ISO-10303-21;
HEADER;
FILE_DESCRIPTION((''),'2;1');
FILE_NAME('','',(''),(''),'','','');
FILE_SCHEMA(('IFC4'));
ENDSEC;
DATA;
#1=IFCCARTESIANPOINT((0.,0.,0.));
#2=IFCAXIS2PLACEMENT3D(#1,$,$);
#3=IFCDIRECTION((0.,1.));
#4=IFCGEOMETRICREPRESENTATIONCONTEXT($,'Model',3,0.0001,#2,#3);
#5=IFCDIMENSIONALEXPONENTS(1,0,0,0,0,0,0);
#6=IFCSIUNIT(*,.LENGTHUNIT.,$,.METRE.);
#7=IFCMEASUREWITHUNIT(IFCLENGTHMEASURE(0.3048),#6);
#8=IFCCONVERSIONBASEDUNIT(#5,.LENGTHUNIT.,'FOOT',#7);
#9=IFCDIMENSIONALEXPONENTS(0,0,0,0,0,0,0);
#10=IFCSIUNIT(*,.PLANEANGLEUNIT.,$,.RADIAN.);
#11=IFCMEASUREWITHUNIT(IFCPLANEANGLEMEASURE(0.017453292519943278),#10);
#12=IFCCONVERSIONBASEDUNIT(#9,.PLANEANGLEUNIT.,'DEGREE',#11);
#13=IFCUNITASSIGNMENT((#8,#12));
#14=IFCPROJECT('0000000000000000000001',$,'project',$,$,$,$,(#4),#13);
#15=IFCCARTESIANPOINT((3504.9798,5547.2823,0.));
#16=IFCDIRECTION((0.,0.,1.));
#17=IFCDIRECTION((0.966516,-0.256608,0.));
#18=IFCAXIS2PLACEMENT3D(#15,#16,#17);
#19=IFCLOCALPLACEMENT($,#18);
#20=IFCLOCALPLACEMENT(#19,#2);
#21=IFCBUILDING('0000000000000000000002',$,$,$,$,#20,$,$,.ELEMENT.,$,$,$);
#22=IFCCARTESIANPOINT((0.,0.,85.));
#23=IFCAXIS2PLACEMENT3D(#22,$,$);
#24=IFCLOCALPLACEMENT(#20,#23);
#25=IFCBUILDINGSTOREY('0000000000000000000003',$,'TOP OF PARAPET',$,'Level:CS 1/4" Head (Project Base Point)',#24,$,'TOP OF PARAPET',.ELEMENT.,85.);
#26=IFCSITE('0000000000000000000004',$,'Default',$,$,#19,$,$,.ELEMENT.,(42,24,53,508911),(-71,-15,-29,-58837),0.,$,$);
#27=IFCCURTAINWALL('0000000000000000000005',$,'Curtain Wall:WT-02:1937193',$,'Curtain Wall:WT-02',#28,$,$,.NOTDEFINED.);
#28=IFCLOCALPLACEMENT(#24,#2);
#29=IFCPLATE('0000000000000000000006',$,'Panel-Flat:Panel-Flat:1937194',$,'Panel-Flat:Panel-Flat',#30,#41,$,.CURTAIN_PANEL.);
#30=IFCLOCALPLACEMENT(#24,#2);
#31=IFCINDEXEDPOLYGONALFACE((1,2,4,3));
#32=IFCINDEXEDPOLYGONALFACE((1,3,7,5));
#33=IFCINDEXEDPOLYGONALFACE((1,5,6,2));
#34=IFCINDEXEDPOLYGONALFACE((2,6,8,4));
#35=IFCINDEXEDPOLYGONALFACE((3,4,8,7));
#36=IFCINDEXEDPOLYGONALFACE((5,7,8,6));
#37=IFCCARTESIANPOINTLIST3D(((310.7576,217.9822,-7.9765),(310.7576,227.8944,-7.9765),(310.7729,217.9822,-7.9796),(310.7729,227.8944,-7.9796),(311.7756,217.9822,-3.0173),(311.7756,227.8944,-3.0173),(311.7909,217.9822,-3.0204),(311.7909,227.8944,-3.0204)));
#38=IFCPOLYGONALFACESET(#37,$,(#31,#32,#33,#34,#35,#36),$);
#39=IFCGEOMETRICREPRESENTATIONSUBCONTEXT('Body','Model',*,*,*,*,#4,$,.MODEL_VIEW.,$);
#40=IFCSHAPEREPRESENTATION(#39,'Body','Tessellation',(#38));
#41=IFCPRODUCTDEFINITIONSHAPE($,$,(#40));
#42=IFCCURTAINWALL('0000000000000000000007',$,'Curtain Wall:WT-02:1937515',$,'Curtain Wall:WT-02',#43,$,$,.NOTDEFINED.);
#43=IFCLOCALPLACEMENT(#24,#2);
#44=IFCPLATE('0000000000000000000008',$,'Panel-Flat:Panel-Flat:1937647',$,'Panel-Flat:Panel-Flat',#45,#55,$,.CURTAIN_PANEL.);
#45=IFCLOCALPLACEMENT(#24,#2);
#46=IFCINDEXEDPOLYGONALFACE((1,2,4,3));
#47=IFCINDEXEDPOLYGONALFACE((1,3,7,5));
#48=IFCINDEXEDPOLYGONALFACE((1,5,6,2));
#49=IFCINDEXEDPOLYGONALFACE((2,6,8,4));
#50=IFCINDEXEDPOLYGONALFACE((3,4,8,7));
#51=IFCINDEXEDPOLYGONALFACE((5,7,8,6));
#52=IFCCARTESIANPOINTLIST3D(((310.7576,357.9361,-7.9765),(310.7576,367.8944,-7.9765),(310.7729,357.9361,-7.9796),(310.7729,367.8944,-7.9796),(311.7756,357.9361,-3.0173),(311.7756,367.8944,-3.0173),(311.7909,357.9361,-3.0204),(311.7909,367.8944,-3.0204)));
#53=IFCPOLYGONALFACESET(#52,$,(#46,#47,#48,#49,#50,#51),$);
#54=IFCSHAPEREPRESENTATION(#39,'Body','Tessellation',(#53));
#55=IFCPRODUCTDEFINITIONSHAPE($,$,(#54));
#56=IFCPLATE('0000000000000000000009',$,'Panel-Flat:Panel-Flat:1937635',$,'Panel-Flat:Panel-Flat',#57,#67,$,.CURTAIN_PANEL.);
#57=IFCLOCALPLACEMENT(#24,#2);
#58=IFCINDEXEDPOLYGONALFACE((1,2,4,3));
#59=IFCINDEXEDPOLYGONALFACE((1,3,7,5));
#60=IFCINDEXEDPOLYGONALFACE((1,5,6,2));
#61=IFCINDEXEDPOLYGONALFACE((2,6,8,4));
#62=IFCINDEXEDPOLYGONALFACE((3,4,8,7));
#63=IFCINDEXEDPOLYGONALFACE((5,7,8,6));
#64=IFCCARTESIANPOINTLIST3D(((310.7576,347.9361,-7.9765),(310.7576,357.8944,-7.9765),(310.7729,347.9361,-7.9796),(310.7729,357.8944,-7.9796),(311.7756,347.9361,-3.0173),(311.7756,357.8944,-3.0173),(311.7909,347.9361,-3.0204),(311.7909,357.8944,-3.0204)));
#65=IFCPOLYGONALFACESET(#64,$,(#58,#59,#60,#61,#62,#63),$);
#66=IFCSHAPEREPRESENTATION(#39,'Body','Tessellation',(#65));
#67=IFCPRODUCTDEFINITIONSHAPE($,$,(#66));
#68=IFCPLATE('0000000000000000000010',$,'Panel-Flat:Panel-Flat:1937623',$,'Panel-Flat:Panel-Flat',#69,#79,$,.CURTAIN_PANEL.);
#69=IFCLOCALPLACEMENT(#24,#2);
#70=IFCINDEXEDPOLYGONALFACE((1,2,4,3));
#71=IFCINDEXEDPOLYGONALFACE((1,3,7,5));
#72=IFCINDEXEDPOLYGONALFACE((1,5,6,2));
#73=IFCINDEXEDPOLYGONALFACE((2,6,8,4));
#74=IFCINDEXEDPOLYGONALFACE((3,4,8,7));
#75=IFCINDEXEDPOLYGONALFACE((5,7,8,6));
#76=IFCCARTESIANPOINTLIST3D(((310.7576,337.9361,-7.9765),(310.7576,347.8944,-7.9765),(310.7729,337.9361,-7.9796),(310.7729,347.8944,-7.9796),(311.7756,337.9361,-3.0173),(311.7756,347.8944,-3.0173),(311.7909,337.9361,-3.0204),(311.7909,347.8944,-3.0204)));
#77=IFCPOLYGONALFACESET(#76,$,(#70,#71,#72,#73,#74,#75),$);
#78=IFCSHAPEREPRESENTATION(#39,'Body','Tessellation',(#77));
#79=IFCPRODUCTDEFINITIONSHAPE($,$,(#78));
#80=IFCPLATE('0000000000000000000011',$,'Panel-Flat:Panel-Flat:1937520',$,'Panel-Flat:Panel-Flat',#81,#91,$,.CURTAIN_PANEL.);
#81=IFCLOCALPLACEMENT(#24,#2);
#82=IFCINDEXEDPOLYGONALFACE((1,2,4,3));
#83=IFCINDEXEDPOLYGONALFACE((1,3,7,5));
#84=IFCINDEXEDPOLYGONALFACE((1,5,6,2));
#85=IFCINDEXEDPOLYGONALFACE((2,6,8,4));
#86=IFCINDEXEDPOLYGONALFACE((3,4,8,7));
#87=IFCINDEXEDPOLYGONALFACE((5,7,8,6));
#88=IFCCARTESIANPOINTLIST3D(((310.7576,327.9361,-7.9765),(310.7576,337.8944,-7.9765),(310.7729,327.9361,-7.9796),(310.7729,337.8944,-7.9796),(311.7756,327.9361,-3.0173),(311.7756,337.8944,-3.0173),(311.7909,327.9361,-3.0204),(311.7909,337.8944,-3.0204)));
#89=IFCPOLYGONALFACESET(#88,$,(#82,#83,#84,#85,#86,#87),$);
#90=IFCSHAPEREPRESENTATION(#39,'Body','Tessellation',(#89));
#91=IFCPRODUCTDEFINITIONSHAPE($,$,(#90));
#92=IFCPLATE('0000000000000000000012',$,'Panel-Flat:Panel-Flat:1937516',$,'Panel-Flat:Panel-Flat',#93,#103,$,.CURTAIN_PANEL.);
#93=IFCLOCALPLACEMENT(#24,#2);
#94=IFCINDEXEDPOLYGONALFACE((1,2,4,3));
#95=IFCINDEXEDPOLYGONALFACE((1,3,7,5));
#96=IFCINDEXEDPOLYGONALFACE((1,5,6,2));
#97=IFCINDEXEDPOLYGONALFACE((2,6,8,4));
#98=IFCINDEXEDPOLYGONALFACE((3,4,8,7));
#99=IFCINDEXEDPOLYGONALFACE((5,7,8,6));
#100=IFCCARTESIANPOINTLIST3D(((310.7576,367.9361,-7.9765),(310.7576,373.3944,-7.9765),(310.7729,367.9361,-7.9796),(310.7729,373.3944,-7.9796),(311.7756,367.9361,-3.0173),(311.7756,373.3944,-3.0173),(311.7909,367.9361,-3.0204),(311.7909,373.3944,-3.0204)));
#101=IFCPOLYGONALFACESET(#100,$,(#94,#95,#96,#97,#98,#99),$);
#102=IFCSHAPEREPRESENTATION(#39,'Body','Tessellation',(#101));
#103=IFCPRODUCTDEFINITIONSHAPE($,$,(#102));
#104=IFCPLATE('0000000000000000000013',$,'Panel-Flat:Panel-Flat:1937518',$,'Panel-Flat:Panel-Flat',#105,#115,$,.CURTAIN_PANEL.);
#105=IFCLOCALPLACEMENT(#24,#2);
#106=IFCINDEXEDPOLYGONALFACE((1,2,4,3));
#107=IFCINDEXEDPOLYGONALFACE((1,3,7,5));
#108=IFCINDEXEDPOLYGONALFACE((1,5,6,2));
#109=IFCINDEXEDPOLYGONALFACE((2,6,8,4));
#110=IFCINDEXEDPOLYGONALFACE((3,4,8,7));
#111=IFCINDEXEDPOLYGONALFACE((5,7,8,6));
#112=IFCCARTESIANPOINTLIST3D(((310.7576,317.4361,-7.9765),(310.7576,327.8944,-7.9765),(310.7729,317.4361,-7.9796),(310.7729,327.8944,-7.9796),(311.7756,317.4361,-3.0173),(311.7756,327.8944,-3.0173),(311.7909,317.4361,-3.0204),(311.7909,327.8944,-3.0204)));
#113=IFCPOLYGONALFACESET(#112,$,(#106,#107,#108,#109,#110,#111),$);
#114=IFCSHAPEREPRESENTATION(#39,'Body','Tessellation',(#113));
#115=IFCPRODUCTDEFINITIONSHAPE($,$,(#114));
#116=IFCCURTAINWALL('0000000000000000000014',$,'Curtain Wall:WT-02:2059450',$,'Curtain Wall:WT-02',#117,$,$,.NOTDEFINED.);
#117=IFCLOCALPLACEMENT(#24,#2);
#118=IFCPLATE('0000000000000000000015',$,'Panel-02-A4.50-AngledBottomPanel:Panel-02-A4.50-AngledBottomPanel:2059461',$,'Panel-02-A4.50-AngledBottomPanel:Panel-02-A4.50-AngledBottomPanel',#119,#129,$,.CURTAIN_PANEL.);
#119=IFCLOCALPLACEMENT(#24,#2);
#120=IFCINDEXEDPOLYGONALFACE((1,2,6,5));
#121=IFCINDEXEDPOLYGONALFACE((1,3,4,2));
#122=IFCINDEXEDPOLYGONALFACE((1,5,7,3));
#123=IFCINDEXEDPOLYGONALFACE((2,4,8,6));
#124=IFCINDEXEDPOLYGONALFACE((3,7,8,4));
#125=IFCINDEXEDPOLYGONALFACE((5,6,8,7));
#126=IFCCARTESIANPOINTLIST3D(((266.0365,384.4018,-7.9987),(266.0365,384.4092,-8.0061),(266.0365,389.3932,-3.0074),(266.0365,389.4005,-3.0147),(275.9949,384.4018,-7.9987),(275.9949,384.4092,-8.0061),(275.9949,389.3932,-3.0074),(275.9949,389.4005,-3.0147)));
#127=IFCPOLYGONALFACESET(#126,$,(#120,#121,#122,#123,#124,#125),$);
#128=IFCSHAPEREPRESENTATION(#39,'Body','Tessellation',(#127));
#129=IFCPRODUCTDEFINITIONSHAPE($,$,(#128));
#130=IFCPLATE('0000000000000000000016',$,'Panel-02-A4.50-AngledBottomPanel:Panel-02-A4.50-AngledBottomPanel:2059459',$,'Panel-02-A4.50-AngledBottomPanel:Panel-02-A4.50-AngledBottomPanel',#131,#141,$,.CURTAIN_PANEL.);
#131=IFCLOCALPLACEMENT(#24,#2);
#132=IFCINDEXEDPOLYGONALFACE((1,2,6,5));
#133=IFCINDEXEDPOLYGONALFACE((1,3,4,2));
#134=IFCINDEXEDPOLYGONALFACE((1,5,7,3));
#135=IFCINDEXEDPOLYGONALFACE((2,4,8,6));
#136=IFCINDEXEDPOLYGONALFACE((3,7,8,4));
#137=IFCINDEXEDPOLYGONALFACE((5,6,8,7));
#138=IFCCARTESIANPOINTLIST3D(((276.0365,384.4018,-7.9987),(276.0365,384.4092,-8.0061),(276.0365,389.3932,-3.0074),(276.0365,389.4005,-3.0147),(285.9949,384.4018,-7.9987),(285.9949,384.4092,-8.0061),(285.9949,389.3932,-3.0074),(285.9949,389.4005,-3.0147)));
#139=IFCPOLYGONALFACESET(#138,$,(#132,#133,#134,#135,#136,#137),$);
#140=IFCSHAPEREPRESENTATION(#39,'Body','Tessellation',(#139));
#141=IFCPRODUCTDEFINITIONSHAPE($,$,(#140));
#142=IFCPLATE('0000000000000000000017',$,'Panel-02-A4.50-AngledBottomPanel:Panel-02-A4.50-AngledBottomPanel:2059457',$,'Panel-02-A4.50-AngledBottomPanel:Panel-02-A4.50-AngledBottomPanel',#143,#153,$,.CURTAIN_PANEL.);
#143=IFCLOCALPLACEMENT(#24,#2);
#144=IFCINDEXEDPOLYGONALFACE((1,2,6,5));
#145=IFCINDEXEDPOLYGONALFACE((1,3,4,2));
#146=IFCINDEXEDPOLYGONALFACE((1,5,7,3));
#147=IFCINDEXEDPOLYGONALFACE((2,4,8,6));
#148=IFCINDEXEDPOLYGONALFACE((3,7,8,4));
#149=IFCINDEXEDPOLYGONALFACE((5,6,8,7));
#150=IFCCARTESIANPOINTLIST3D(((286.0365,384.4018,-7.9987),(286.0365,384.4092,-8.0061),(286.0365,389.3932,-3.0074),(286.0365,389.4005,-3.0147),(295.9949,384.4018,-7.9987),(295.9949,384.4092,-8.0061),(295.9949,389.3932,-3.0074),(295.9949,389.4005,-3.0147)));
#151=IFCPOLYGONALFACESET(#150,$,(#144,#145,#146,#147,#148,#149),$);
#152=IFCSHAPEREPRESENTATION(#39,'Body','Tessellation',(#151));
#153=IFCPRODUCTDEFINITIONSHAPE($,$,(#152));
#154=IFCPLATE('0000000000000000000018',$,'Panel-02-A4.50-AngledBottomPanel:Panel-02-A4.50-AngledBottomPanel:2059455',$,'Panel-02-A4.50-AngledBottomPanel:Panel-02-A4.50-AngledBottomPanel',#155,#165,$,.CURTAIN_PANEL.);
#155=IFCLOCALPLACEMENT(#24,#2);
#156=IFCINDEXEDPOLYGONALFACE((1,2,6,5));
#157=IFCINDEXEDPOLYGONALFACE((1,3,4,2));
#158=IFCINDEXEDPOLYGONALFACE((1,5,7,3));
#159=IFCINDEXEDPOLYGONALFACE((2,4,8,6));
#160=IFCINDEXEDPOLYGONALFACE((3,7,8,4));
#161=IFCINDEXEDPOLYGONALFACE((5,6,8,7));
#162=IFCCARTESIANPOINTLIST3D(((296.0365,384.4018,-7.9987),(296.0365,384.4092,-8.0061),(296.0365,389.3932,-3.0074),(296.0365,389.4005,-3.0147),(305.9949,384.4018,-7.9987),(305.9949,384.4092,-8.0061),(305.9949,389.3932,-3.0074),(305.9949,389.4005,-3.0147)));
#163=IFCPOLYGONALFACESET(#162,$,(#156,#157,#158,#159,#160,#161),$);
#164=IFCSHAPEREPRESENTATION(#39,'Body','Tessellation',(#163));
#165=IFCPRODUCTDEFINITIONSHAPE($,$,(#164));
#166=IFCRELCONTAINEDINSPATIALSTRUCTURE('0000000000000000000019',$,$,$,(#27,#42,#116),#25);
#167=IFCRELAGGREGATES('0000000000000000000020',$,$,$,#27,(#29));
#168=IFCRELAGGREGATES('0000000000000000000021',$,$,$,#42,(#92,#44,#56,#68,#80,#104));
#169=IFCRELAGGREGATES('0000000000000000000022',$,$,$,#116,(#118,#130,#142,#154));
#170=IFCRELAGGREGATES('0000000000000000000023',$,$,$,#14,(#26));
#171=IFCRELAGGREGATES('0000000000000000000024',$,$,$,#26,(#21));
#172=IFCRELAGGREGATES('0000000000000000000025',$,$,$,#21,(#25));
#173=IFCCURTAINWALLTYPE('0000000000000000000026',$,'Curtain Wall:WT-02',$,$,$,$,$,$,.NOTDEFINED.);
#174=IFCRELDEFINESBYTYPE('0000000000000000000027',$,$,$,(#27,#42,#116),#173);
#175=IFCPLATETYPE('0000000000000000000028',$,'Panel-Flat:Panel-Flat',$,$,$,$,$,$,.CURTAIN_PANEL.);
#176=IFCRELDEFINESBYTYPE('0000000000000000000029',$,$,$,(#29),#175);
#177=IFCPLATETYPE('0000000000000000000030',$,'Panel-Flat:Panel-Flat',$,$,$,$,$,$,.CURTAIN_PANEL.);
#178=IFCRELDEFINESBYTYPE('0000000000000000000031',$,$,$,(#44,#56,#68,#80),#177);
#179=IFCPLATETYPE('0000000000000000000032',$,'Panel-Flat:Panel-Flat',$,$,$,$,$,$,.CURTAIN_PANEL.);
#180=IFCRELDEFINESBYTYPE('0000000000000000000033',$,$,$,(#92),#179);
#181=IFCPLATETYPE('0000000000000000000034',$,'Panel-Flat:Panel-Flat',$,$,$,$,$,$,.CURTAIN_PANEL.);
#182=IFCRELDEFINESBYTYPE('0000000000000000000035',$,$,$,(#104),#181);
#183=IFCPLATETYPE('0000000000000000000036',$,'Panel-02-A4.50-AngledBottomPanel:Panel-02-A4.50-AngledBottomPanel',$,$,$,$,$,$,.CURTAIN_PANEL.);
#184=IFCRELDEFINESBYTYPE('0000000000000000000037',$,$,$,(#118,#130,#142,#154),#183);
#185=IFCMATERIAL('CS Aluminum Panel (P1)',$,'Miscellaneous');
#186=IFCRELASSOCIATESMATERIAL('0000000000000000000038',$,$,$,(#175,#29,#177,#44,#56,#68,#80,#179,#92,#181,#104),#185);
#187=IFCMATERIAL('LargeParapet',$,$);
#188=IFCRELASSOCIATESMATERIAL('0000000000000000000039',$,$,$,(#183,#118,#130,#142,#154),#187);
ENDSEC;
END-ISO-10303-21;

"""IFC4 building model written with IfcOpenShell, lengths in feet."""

from ifc_helpers import new_model, entity, si_unit, converted_unit, direction, frame, origin, place, context, subcontext, project, spatial, indexed_curve, outline, extrude, source, transform, mapped, material, type_object, type_shapes, element, aggregate, save


model = new_model("IFC4")

# Units and contexts
model_context = context("Model", 3, precision=0.0001, world=origin(), true_north=direction((0.0, 1.0)))
body_context = subcontext(model_context, "Body", "Model", "MODEL_VIEW")
ifc_project = project(units=[converted_unit("LENGTHUNIT", "FOOT", entity("IfcLengthMeasure", 0.3048), si_unit("LENGTHUNIT", "METRE"), dimensions=[1, 0, 0, 0, 0, 0, 0]), converted_unit("PLANEANGLEUNIT", "DEGREE", entity("IfcPlaneAngleMeasure", 0.017453292519943278), si_unit("PLANEANGLEUNIT", "RADIAN"), dimensions=[0, 0, 0, 0, 0, 0, 0])], contexts=[model_context])

# Site, building, storey
site_placement = place(None, frame((3504.9798, 5547.2823, 0.0), z_axis=(0.0, 0.0, 1.0), x_axis=(0.966516, -0.256608, 0.0)))
site = spatial("IfcSite", under=ifc_project, at=site_placement, Name="Default", CompositionType="ELEMENT", RefLatitude=(42, 24, 53, 508911), RefLongitude=(-71, -15, -29, -58837), RefElevation=0.0)
building_placement = place(site_placement, origin())
building = spatial("IfcBuilding", under=site, at=building_placement, CompositionType="ELEMENT")
storey_placement = place(building_placement, frame((0.0, 0.0, 85.0)))
storey = spatial("IfcBuildingStorey", under=building, at=storey_placement, Name="TOP OF PARAPET", ObjectType="Level:CS 1/4\" Head (Project Base Point)", LongName="TOP OF PARAPET", CompositionType="ELEMENT", Elevation=85.0)

# Shared definitions
curtain_wall_type = type_object("IfcCurtainWallType", Name="Curtain Wall:WT-02", PredefinedType="NOTDEFINED")
ifc_material_1 = material(Name="LargeParapet")

# Curtain wall, plate
curtain_wall_1_placement = place(storey_placement, frame((0.0, 0.0, -85.0)))
curtain_wall_1 = element("IfcCurtainWall", 1, at=curtain_wall_1_placement, inside=storey, type_object=curtain_wall_type, Name="Curtain Wall:WT-02:1937193", ObjectType="Curtain Wall:WT-02", PredefinedType="NOTDEFINED")
ifc_material_2 = material(Name="CS Aluminum Panel (P1)", Category="Miscellaneous")
plate_type_1 = type_object("IfcPlateType", Name="Panel-Flat:Panel-Flat", PredefinedType="CURTAIN_PANEL", material=ifc_material_2)
shared_shape_1 = source(origin(), body_context, "Body", "SweptSolid", [
    extrude(outline(indexed_curve([(-0.0078, -4.9561), (0.0078, -4.9561), (0.0078, 4.9561), (-0.0078, 4.9561), (-0.0078, -4.9561)], self_intersect=False)), frame((4.9561, 0.0078, 0.0), z_axis=(0.0, 0.0, 1.0), x_axis=(0.0, -1.0, 0.0)), (0.0, 0.0, 1.0), 5.0626),
])
type_shapes(plate_type_1, [shared_shape_1])
plate_1_placement = place(curtain_wall_1_placement, frame((310.7576, 227.8944, 77.0235), z_axis=(0.201078, 0.0, 0.979575), x_axis=(0.0, -1.0, 0.0)))
plate_1 = element("IfcPlate", 2, at=plate_1_placement, type_object=plate_type_1, material=ifc_material_2, Name="Panel-Flat:Panel-Flat:1937194", ObjectType="Panel-Flat:Panel-Flat", PredefinedType="CURTAIN_PANEL", context=body_context, shape_type="MappedRepresentation", body=[
    mapped(shared_shape_1, transform((0.0, 0.0, 0.0), scale=1.0)),
])
aggregate(curtain_wall_1, [plate_1])

# Curtain wall, plates
curtain_wall_2_placement = place(storey_placement, frame((0.0, 0.0, -85.0)))
curtain_wall_2 = element("IfcCurtainWall", 3, at=curtain_wall_2_placement, inside=storey, type_object=curtain_wall_type, Name="Curtain Wall:WT-02:1937515", ObjectType="Curtain Wall:WT-02", PredefinedType="NOTDEFINED")
plate_type_2 = type_object("IfcPlateType", Name="Panel-Flat:Panel-Flat", PredefinedType="CURTAIN_PANEL", material=ifc_material_2)
shared_shape_2 = source(origin(), body_context, "Body", "SweptSolid", [
    extrude(outline(indexed_curve([(-0.0078, -4.9792), (0.0078, -4.9792), (0.0078, 4.9792), (-0.0078, 4.9792), (-0.0078, -4.9792)], self_intersect=False)), frame((4.9792, 0.0078, 0.0), z_axis=(0.0, 0.0, 1.0), x_axis=(0.0, -1.0, 0.0)), (0.0, 0.0, 1.0), 5.0626),
])
type_shapes(plate_type_2, [shared_shape_2])
plate_2_placement = place(curtain_wall_2_placement, frame((310.7576, 367.8944, 77.0235), z_axis=(0.201078, 0.0, 0.979575), x_axis=(0.0, -1.0, 0.0)))
plate_2 = element("IfcPlate", 4, at=plate_2_placement, type_object=plate_type_2, material=ifc_material_2, Name="Panel-Flat:Panel-Flat:1937647", ObjectType="Panel-Flat:Panel-Flat", PredefinedType="CURTAIN_PANEL", context=body_context, shape_type="MappedRepresentation", body=[
    mapped(shared_shape_2, transform((0.0, 0.0, 0.0), scale=1.0)),
])
plate_3_placement = place(curtain_wall_2_placement, frame((310.7576, 357.8944, 77.0235), z_axis=(0.201078, 0.0, 0.979575), x_axis=(0.0, -1.0, 0.0)))
plate_3 = element("IfcPlate", 5, at=plate_3_placement, type_object=plate_type_2, material=ifc_material_2, Name="Panel-Flat:Panel-Flat:1937635", ObjectType="Panel-Flat:Panel-Flat", PredefinedType="CURTAIN_PANEL", context=body_context, shape_type="MappedRepresentation", body=[
    mapped(shared_shape_2, transform((0.0, 0.0, 0.0), scale=1.0)),
])
plate_4_placement = place(curtain_wall_2_placement, frame((310.7576, 347.8944, 77.0235), z_axis=(0.201078, 0.0, 0.979575), x_axis=(0.0, -1.0, 0.0)))
plate_4 = element("IfcPlate", 6, at=plate_4_placement, type_object=plate_type_2, material=ifc_material_2, Name="Panel-Flat:Panel-Flat:1937623", ObjectType="Panel-Flat:Panel-Flat", PredefinedType="CURTAIN_PANEL", context=body_context, shape_type="MappedRepresentation", body=[
    mapped(shared_shape_2, transform((0.0, 0.0, 0.0), scale=1.0)),
])
plate_5_placement = place(curtain_wall_2_placement, frame((310.7576, 337.8944, 77.0235), z_axis=(0.201078, 0.0, 0.979575), x_axis=(0.0, -1.0, 0.0)))
plate_5 = element("IfcPlate", 7, at=plate_5_placement, type_object=plate_type_2, material=ifc_material_2, Name="Panel-Flat:Panel-Flat:1937520", ObjectType="Panel-Flat:Panel-Flat", PredefinedType="CURTAIN_PANEL", context=body_context, shape_type="MappedRepresentation", body=[
    mapped(shared_shape_2, transform((0.0, 0.0, 0.0), scale=1.0)),
])
plate_type_3 = type_object("IfcPlateType", Name="Panel-Flat:Panel-Flat", PredefinedType="CURTAIN_PANEL", material=ifc_material_2)
shared_shape_3 = source(origin(), body_context, "Body", "SweptSolid", [
    extrude(outline(indexed_curve([(-0.0078, -2.7292), (0.0078, -2.7292), (0.0078, 2.7292), (-0.0078, 2.7292), (-0.0078, -2.7292)], self_intersect=False)), frame((2.7292, 0.0078, 0.0), z_axis=(0.0, 0.0, 1.0), x_axis=(0.0, -1.0, 0.0)), (0.0, 0.0, 1.0), 5.0626),
])
type_shapes(plate_type_3, [shared_shape_3])
plate_6_placement = place(curtain_wall_2_placement, frame((310.7576, 373.3944, 77.0235), z_axis=(0.201078, 0.0, 0.979575), x_axis=(0.0, -1.0, 0.0)))
plate_6 = element("IfcPlate", 8, at=plate_6_placement, type_object=plate_type_3, material=ifc_material_2, Name="Panel-Flat:Panel-Flat:1937516", ObjectType="Panel-Flat:Panel-Flat", PredefinedType="CURTAIN_PANEL", context=body_context, shape_type="MappedRepresentation", body=[
    mapped(shared_shape_3, transform((0.0, 0.0, 0.0), scale=1.0)),
])
plate_type_4 = type_object("IfcPlateType", Name="Panel-Flat:Panel-Flat", PredefinedType="CURTAIN_PANEL", material=ifc_material_2)
shared_shape_4 = source(origin(), body_context, "Body", "SweptSolid", [
    extrude(outline(indexed_curve([(-0.0078, -5.2292), (0.0078, -5.2292), (0.0078, 5.2292), (-0.0078, 5.2292), (-0.0078, -5.2292)], self_intersect=False)), frame((5.2292, 0.0078, 0.0), z_axis=(0.0, 0.0, 1.0), x_axis=(0.0, -1.0, 0.0)), (0.0, 0.0, 1.0), 5.0626),
])
type_shapes(plate_type_4, [shared_shape_4])
plate_7_placement = place(curtain_wall_2_placement, frame((310.7576, 327.8944, 77.0235), z_axis=(0.201078, 0.0, 0.979575), x_axis=(0.0, -1.0, 0.0)))
plate_7 = element("IfcPlate", 9, at=plate_7_placement, type_object=plate_type_4, material=ifc_material_2, Name="Panel-Flat:Panel-Flat:1937518", ObjectType="Panel-Flat:Panel-Flat", PredefinedType="CURTAIN_PANEL", context=body_context, shape_type="MappedRepresentation", body=[
    mapped(shared_shape_4, transform((0.0, 0.0, 0.0), scale=1.0)),
])
aggregate(curtain_wall_2, [plate_6, plate_2, plate_3, plate_4, plate_5, plate_7])

# Curtain wall, plates
curtain_wall_3_placement = place(storey_placement, frame((0.0, 0.0, -85.0)))
curtain_wall_3 = element("IfcCurtainWall", 10, at=curtain_wall_3_placement, inside=storey, type_object=curtain_wall_type, Name="Curtain Wall:WT-02:2059450", ObjectType="Curtain Wall:WT-02", PredefinedType="NOTDEFINED")
plate_type_5 = type_object("IfcPlateType", Name="Panel-02-A4.50-AngledBottomPanel:Panel-02-A4.50-AngledBottomPanel", PredefinedType="CURTAIN_PANEL", material=ifc_material_1)
shared_shape_5 = source(origin(), body_context, "Body", "SweptSolid", [
    extrude(outline(indexed_curve([(-0.0052, -4.9792), (0.0052, -4.9792), (0.0052, 4.9792), (-0.0052, 4.9792), (-0.0052, -4.9792)], self_intersect=False)), frame((4.9792, 0.0052, 0.0), z_axis=(0.0, 0.0, 1.0), x_axis=(0.0, -1.0, 0.0)), (0.0, 0.0, 1.0), 7.0589),
])
type_shapes(plate_type_5, [shared_shape_5])
plate_8_placement = place(curtain_wall_3_placement, frame((266.0365, 384.4018, 77.0013), z_axis=(0.0, 0.707107, 0.707107), x_axis=(1.0, 0.0, 0.0)))
plate_8 = element("IfcPlate", 11, at=plate_8_placement, type_object=plate_type_5, material=ifc_material_1, Name="Panel-02-A4.50-AngledBottomPanel:Panel-02-A4.50-AngledBottomPanel:2059461", ObjectType="Panel-02-A4.50-AngledBottomPanel:Panel-02-A4.50-AngledBottomPanel", PredefinedType="CURTAIN_PANEL", context=body_context, shape_type="MappedRepresentation", body=[
    mapped(shared_shape_5, transform((0.0, 0.0, 0.0), scale=1.0)),
])
plate_9_placement = place(curtain_wall_3_placement, frame((276.0365, 384.4018, 77.0013), z_axis=(0.0, 0.707107, 0.707107), x_axis=(1.0, 0.0, 0.0)))
plate_9 = element("IfcPlate", 12, at=plate_9_placement, type_object=plate_type_5, material=ifc_material_1, Name="Panel-02-A4.50-AngledBottomPanel:Panel-02-A4.50-AngledBottomPanel:2059459", ObjectType="Panel-02-A4.50-AngledBottomPanel:Panel-02-A4.50-AngledBottomPanel", PredefinedType="CURTAIN_PANEL", context=body_context, shape_type="MappedRepresentation", body=[
    mapped(shared_shape_5, transform((0.0, 0.0, 0.0), scale=1.0)),
])
plate_10_placement = place(curtain_wall_3_placement, frame((286.0365, 384.4018, 77.0013), z_axis=(0.0, 0.707107, 0.707107), x_axis=(1.0, 0.0, 0.0)))
plate_10 = element("IfcPlate", 13, at=plate_10_placement, type_object=plate_type_5, material=ifc_material_1, Name="Panel-02-A4.50-AngledBottomPanel:Panel-02-A4.50-AngledBottomPanel:2059457", ObjectType="Panel-02-A4.50-AngledBottomPanel:Panel-02-A4.50-AngledBottomPanel", PredefinedType="CURTAIN_PANEL", context=body_context, shape_type="MappedRepresentation", body=[
    mapped(shared_shape_5, transform((0.0, 0.0, 0.0), scale=1.0)),
])
plate_11_placement = place(curtain_wall_3_placement, frame((296.0365, 384.4018, 77.0013), z_axis=(0.0, 0.707107, 0.707107), x_axis=(1.0, 0.0, 0.0)))
plate_11 = element("IfcPlate", 14, at=plate_11_placement, type_object=plate_type_5, material=ifc_material_1, Name="Panel-02-A4.50-AngledBottomPanel:Panel-02-A4.50-AngledBottomPanel:2059455", ObjectType="Panel-02-A4.50-AngledBottomPanel:Panel-02-A4.50-AngledBottomPanel", PredefinedType="CURTAIN_PANEL", context=body_context, shape_type="MappedRepresentation", body=[
    mapped(shared_shape_5, transform((0.0, 0.0, 0.0), scale=1.0)),
])
aggregate(curtain_wall_3, [plate_8, plate_9, plate_10, plate_11])

save(model, "model.ifc")
